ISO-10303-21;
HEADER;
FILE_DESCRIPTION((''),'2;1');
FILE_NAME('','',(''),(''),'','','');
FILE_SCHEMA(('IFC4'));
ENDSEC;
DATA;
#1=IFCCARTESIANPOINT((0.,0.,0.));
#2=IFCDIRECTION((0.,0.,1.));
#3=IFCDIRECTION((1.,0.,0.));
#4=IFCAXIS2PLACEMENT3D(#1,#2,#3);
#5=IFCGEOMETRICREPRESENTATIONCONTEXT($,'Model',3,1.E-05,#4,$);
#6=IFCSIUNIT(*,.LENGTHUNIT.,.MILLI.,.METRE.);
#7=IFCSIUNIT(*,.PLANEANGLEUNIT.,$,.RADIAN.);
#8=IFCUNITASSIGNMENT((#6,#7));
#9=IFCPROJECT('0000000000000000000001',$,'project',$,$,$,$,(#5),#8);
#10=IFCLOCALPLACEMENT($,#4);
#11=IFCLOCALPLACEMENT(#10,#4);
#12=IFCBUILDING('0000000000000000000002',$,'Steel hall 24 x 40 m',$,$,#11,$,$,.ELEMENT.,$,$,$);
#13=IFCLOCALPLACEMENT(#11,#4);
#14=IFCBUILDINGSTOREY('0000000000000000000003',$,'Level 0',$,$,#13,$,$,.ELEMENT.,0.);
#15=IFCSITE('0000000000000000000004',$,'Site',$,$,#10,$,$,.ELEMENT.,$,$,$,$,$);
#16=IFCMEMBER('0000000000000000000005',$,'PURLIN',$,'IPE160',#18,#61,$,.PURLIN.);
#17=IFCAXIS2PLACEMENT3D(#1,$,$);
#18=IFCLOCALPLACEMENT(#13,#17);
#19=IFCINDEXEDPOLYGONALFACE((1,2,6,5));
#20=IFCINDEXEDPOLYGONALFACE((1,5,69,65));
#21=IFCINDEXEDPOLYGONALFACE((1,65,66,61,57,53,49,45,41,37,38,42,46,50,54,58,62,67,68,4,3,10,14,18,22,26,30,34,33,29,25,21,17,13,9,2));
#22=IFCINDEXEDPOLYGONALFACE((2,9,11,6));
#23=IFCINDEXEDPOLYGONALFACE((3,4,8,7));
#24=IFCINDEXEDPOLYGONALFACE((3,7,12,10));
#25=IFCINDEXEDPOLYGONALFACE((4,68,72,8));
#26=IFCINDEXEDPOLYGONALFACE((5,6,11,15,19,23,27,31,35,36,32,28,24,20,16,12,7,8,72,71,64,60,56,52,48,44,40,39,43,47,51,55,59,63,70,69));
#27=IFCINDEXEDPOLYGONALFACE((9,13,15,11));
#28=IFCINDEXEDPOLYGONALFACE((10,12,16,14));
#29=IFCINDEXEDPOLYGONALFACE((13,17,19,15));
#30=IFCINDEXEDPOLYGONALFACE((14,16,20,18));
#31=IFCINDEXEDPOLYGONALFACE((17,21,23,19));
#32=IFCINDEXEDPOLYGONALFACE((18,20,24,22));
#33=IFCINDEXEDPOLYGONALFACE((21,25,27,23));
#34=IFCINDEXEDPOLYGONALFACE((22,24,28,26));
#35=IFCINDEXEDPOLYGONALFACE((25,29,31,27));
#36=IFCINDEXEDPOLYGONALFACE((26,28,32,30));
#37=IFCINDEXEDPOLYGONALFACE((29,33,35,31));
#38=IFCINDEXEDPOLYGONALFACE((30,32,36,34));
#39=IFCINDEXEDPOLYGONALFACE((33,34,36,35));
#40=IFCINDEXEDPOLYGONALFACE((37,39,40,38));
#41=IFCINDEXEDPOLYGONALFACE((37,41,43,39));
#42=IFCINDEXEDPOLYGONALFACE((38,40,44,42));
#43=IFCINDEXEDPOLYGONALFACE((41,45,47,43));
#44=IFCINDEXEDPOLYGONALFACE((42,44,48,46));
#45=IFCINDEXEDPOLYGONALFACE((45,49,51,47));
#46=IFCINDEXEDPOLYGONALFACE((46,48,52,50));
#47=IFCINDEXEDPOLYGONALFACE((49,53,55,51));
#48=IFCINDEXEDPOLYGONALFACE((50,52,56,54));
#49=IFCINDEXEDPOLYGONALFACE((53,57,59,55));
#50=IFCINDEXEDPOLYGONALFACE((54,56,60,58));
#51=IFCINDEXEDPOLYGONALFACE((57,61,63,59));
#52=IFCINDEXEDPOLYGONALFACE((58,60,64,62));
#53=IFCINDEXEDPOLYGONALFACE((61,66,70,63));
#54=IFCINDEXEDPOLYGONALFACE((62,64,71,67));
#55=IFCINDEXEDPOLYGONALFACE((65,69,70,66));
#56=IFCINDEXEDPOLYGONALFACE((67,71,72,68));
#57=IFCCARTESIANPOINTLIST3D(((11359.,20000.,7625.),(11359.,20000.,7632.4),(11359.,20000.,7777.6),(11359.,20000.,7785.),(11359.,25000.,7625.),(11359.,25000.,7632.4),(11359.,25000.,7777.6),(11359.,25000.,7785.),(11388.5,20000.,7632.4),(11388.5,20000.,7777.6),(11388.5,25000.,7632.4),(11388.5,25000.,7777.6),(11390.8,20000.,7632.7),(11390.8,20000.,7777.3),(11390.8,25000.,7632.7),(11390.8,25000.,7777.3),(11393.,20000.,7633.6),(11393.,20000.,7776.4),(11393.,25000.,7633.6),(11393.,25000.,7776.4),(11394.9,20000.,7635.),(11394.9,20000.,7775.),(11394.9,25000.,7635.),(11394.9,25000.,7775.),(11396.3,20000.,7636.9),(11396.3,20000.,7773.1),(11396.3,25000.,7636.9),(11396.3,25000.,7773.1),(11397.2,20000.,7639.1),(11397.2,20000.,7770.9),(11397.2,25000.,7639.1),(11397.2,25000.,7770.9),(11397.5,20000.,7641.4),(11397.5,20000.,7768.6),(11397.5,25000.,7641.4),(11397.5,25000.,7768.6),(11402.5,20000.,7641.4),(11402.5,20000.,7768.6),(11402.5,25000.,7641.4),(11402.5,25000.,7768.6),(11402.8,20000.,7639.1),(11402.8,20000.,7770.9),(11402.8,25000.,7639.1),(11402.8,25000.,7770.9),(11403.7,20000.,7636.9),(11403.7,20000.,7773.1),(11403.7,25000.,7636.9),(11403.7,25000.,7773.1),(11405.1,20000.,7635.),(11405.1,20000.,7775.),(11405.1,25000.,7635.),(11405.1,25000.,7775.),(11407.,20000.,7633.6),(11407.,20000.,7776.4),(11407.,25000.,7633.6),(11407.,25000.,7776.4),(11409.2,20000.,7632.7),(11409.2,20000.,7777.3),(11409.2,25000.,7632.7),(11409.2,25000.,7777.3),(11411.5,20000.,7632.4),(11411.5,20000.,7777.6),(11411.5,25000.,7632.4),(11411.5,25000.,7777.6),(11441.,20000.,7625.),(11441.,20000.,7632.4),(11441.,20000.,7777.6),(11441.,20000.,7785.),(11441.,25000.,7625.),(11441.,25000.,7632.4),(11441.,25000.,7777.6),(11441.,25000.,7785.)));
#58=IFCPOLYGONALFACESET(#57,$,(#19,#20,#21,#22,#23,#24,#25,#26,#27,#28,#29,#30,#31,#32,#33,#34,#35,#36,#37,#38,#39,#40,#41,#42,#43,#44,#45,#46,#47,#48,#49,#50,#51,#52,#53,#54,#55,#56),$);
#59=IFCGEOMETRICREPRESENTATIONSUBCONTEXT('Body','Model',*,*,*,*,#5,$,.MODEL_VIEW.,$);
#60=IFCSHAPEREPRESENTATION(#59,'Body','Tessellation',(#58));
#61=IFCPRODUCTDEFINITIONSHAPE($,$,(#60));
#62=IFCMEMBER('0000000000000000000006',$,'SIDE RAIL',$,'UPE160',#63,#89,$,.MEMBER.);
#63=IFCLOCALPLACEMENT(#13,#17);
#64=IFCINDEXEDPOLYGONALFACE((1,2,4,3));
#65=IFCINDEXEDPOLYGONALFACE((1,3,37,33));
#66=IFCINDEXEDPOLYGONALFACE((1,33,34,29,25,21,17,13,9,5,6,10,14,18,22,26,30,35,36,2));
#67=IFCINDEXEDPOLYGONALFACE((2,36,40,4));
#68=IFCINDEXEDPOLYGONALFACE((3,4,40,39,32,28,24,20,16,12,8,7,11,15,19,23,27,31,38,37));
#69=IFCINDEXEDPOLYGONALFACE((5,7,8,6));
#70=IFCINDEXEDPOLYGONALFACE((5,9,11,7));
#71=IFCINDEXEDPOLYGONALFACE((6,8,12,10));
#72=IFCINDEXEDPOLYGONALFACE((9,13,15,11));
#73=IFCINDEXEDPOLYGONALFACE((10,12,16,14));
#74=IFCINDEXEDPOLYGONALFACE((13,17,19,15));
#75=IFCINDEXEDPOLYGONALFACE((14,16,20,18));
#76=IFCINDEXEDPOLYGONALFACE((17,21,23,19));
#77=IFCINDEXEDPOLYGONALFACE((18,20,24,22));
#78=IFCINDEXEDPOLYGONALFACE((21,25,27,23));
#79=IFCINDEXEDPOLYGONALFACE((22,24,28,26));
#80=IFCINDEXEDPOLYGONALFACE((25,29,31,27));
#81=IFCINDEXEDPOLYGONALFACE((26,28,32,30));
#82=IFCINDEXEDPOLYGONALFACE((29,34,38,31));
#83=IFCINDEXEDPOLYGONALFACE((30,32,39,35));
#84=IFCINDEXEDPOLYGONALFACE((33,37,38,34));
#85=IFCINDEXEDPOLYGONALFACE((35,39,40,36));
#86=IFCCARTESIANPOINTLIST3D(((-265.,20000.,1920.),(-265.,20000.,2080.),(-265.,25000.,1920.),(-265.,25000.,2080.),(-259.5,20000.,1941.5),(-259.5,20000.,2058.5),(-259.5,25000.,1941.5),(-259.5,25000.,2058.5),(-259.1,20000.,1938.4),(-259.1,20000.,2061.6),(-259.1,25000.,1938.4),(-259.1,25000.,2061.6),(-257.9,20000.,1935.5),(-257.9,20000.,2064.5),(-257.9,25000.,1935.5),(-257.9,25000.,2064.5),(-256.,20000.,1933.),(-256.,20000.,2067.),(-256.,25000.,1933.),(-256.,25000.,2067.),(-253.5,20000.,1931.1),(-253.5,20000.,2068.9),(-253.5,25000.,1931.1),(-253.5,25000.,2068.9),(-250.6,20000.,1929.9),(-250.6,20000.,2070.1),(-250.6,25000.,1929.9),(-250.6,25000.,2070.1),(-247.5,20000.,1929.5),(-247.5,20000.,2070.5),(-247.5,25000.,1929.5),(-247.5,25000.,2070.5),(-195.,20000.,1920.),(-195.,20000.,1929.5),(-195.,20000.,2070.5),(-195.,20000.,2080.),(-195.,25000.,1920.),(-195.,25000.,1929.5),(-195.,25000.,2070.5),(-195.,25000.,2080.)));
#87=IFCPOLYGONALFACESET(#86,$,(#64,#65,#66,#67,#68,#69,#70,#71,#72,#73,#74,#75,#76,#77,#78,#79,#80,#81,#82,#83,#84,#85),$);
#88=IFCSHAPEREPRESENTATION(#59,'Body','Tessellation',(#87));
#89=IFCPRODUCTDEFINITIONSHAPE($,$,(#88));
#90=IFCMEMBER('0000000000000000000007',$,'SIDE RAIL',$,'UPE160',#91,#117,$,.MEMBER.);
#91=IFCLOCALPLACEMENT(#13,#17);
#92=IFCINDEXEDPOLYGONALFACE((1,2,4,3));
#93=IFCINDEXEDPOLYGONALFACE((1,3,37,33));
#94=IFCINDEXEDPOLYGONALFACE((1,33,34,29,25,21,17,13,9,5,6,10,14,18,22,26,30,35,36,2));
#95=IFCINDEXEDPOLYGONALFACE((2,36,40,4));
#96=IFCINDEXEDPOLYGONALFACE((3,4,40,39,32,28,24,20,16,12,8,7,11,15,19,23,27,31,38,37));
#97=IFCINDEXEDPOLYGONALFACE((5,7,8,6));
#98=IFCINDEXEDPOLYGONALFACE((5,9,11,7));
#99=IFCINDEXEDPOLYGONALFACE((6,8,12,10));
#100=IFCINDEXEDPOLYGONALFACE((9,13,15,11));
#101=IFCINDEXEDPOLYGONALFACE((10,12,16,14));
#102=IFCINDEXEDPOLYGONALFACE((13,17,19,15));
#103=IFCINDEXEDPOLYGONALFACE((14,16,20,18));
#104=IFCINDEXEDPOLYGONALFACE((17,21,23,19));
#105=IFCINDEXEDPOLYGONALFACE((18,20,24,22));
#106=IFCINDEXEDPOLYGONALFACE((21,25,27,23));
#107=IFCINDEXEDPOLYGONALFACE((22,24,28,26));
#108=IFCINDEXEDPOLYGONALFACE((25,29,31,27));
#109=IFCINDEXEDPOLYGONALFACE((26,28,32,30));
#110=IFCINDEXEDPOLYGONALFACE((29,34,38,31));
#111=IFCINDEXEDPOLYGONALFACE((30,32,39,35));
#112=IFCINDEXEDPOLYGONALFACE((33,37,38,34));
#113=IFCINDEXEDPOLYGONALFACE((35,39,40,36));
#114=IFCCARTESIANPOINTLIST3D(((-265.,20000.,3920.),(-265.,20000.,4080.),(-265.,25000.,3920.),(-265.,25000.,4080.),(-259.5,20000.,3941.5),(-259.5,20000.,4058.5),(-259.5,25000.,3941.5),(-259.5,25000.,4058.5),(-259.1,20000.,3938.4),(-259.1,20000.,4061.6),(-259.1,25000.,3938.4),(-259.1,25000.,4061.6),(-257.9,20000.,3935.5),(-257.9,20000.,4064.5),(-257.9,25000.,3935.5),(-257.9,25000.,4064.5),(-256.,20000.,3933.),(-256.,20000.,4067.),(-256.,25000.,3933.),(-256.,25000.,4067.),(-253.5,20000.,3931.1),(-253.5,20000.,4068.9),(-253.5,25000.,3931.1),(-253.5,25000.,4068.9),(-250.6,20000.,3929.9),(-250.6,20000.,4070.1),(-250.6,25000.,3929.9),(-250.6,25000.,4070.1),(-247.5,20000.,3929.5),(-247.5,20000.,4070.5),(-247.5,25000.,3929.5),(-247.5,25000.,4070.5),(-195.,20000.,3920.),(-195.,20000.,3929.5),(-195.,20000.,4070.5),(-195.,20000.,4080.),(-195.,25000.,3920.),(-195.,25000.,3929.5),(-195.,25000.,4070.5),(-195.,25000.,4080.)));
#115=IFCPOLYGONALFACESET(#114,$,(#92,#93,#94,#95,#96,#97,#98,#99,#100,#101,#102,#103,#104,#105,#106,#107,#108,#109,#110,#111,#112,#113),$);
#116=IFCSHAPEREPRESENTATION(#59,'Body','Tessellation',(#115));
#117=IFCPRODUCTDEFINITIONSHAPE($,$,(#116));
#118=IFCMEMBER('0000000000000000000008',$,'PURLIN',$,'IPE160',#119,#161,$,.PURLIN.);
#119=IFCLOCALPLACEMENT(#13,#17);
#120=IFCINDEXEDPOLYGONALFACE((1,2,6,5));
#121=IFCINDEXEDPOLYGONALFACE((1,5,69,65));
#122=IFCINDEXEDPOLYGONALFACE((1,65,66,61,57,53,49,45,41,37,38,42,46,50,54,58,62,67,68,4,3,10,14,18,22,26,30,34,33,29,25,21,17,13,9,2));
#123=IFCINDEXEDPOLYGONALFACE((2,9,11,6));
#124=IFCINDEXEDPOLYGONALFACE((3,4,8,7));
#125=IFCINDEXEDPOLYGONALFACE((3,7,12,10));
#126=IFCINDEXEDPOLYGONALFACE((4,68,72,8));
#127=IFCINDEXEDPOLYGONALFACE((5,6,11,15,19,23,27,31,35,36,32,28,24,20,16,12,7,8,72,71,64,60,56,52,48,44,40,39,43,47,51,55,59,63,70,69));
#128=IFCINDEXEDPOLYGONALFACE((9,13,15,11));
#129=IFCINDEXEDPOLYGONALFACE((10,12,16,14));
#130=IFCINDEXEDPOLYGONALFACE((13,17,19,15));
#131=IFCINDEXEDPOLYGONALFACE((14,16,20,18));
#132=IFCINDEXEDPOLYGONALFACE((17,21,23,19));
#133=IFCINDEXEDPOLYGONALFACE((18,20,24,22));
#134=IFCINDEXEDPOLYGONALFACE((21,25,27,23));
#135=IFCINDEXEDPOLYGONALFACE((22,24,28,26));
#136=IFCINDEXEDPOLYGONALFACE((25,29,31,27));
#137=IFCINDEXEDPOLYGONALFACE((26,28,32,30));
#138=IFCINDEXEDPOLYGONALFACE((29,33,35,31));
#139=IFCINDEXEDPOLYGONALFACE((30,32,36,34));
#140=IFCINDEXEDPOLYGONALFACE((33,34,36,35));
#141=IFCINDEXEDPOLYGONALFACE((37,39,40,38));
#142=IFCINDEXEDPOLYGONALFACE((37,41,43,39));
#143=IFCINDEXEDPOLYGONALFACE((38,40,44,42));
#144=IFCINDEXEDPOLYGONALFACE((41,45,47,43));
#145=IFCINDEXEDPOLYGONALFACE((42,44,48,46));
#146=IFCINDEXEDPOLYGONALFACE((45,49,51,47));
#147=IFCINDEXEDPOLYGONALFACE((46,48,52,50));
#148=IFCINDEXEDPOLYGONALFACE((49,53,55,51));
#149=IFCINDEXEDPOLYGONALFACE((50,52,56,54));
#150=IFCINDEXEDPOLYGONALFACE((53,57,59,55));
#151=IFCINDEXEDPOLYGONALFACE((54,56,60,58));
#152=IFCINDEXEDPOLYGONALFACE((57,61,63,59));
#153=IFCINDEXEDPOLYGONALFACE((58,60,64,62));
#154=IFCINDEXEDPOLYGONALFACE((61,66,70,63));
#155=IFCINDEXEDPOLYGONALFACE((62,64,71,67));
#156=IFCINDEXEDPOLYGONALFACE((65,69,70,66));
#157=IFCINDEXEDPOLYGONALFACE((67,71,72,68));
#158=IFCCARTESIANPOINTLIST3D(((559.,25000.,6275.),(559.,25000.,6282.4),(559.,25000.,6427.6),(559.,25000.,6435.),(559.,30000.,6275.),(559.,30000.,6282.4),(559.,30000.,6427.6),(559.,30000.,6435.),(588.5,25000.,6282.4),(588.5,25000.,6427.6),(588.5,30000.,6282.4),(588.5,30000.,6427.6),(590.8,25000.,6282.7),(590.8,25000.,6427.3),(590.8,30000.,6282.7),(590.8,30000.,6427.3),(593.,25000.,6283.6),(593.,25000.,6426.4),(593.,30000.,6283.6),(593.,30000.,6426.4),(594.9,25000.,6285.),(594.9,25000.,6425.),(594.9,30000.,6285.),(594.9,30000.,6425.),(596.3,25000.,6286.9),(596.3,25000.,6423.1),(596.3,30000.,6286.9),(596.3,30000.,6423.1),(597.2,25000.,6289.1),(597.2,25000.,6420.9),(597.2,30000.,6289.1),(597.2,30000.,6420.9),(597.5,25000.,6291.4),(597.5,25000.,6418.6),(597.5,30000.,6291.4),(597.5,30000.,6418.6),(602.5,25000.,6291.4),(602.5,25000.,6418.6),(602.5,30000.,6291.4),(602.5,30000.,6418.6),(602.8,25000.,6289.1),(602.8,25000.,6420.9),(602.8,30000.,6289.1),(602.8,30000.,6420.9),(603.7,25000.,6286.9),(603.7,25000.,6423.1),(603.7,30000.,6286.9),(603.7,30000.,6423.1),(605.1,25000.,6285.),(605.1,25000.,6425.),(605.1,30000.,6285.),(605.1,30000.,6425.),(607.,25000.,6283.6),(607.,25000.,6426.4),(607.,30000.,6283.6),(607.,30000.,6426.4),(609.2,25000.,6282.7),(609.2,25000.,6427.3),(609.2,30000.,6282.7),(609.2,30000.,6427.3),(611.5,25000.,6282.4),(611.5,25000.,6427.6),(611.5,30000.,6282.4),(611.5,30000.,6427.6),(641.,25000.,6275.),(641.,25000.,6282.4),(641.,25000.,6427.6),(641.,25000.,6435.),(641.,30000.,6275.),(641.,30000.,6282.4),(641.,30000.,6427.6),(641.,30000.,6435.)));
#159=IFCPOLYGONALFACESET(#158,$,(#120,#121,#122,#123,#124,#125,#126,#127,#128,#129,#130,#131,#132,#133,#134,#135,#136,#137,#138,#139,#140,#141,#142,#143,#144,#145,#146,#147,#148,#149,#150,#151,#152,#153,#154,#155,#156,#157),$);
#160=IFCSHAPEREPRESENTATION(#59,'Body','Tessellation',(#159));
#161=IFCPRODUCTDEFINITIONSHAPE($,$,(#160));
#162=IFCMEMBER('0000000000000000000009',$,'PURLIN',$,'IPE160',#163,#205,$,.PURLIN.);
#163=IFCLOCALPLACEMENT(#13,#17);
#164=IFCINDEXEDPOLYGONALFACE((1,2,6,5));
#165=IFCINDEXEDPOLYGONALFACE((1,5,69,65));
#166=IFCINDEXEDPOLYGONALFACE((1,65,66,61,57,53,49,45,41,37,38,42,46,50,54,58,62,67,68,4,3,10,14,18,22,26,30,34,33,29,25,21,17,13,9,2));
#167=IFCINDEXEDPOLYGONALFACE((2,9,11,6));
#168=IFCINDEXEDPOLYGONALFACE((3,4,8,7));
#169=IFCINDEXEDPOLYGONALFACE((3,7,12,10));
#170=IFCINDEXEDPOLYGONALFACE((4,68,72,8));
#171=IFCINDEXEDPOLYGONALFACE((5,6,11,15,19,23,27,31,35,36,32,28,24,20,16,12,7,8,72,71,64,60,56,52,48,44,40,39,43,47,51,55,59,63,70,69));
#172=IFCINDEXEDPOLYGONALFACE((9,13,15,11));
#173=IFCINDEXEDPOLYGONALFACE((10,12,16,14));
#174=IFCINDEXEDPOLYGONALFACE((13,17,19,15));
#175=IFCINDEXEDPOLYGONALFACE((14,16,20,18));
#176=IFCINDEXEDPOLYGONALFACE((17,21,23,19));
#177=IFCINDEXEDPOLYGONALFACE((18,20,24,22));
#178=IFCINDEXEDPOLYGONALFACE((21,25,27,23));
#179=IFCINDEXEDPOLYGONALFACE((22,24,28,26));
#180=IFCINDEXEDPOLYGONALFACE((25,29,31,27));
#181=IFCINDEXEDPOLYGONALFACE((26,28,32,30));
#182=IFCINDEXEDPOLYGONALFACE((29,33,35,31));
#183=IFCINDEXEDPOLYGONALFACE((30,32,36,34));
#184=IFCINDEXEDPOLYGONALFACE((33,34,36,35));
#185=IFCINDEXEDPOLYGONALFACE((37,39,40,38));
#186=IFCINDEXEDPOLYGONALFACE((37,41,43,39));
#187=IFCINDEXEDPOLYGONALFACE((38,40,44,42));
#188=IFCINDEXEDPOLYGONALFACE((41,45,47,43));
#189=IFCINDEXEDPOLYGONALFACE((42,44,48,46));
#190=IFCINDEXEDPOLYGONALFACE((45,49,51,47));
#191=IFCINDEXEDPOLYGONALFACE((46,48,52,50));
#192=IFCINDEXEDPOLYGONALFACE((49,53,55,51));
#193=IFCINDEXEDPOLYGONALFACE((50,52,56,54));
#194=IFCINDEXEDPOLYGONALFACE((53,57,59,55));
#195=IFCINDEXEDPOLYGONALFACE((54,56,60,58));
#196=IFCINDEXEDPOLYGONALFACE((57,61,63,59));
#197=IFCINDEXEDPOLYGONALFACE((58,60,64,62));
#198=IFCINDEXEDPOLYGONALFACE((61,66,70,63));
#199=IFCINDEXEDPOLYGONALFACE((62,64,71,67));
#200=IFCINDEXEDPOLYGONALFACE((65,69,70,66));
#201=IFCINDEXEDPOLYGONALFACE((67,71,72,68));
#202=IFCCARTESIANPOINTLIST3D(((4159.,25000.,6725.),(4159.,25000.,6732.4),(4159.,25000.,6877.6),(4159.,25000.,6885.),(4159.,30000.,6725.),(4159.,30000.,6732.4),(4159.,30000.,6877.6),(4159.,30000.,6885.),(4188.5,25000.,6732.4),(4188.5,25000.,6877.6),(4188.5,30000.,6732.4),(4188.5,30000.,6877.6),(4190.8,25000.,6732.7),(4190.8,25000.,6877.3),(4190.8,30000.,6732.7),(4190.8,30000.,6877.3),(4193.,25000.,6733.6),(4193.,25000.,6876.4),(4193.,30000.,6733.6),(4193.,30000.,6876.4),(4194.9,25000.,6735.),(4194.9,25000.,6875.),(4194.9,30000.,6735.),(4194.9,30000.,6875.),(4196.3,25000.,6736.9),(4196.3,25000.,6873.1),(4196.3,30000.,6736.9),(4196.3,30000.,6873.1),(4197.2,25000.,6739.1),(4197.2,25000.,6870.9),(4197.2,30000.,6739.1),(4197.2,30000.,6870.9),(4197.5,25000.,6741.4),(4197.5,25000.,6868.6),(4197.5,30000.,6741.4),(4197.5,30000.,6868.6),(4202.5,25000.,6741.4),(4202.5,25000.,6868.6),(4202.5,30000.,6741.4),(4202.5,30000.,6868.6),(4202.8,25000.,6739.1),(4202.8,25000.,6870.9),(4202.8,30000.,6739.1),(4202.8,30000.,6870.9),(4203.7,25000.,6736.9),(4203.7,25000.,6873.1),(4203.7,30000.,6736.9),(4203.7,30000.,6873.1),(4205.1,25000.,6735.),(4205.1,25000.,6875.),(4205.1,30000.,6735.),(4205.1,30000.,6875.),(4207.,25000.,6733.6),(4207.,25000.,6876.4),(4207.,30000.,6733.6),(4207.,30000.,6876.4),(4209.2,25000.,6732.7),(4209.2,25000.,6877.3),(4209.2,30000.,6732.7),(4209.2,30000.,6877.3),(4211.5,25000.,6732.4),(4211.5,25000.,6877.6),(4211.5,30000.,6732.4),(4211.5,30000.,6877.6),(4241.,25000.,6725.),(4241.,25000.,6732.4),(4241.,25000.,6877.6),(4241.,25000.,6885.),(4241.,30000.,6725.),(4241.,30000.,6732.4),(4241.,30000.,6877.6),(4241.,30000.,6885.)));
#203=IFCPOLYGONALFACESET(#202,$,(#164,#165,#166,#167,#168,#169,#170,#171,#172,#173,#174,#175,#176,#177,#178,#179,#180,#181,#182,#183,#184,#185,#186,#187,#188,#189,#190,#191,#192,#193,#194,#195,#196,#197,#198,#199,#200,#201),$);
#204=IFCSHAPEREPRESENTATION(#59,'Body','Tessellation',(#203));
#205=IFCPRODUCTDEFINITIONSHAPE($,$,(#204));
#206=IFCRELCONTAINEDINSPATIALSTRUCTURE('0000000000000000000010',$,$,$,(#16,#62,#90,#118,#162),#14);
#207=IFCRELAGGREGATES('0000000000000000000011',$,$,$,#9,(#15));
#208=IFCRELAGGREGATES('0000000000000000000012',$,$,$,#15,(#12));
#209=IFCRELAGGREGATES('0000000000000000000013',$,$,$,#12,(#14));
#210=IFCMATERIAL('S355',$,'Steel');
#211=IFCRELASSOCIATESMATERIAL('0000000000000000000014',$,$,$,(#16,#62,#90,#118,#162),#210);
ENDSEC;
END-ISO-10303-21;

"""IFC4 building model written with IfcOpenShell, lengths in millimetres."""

from ifc_helpers import new_model, si_unit, frame, origin_with_axes, place, context, subcontext, project, spatial, i_section, u_section, extrude, material, element, save


model = new_model("IFC4")

# Units and contexts
model_context = context("Model", 3, precision=1e-05, world=origin_with_axes())
body_context = subcontext(model_context, "Body", "Model", "MODEL_VIEW")
ifc_project = project(units=[si_unit("LENGTHUNIT", "METRE", prefix="MILLI"), si_unit("PLANEANGLEUNIT", "RADIAN")], contexts=[model_context])

# Site, building, storey
site_placement = place(None, origin_with_axes())
site = spatial("IfcSite", under=ifc_project, at=site_placement, Name="Site", CompositionType="ELEMENT")
building_placement = place(site_placement, origin_with_axes())
building = spatial("IfcBuilding", under=site, at=building_placement, Name="Steel hall 24 x 40 m", CompositionType="ELEMENT")
storey_placement = place(building_placement, origin_with_axes())
storey = spatial("IfcBuildingStorey", under=building, at=storey_placement, Name="Level 0", CompositionType="ELEMENT", Elevation=0.0)

# Shared definitions
ifc_material = material(Name="S355", Category="Steel")

# Members
for number, where, z_axis, x_axis, name in (
    (1, (11400.0, 20000.0, 7705.0), (0.0, 1.0, 0.0), (1.0, 0.0, 0.0), "PURLIN"),
):
    element("IfcMember", number, at=place(storey_placement, frame(where, z_axis=z_axis, x_axis=x_axis)), inside=storey, material=ifc_material, Name=name, ObjectType="IPE160", PredefinedType="PURLIN", context=body_context, shape_type="SweptSolid", body=[
        extrude(i_section(OverallWidth=82.0, OverallDepth=160.0, WebThickness=5.0, FlangeThickness=7.4, FilletRadius=9.0), origin_with_axes(), (0.0, 0.0, 1.0), 5000.0),
    ])
for number, where, z_axis, x_axis, name in (
    (2, (-230.0, 20000.0, 2000.0), (0.0, 1.0, 0.0), (1.0, 0.0, 0.0), "SIDE RAIL"),
    (3, (-230.0, 20000.0, 4000.0), (0.0, 1.0, 0.0), (1.0, 0.0, 0.0), "SIDE RAIL"),
):
    element("IfcMember", number, at=place(storey_placement, frame(where, z_axis=z_axis, x_axis=x_axis)), inside=storey, material=ifc_material, Name=name, ObjectType="UPE160", PredefinedType="MEMBER", context=body_context, shape_type="SweptSolid", body=[
        extrude(u_section(Depth=160.0, FlangeWidth=70.0, WebThickness=5.5, FlangeThickness=9.5, FilletRadius=12.0), origin_with_axes(), (0.0, 0.0, 1.0), 5000.0),
    ])
for number, where, z_axis, x_axis, name in (
    (4, (600.0, 25000.0, 6355.0), (0.0, 1.0, 0.0), (1.0, 0.0, 0.0), "PURLIN"),
    (5, (4200.0, 25000.0, 6805.0), (0.0, 1.0, 0.0), (1.0, 0.0, 0.0), "PURLIN"),
):
    element("IfcMember", number, at=place(storey_placement, frame(where, z_axis=z_axis, x_axis=x_axis)), inside=storey, material=ifc_material, Name=name, ObjectType="IPE160", PredefinedType="PURLIN", context=body_context, shape_type="SweptSolid", body=[
        extrude(i_section(OverallWidth=82.0, OverallDepth=160.0, WebThickness=5.0, FlangeThickness=7.4, FilletRadius=9.0), origin_with_axes(), (0.0, 0.0, 1.0), 5000.0),
    ])

save(model, "model.ifc")
